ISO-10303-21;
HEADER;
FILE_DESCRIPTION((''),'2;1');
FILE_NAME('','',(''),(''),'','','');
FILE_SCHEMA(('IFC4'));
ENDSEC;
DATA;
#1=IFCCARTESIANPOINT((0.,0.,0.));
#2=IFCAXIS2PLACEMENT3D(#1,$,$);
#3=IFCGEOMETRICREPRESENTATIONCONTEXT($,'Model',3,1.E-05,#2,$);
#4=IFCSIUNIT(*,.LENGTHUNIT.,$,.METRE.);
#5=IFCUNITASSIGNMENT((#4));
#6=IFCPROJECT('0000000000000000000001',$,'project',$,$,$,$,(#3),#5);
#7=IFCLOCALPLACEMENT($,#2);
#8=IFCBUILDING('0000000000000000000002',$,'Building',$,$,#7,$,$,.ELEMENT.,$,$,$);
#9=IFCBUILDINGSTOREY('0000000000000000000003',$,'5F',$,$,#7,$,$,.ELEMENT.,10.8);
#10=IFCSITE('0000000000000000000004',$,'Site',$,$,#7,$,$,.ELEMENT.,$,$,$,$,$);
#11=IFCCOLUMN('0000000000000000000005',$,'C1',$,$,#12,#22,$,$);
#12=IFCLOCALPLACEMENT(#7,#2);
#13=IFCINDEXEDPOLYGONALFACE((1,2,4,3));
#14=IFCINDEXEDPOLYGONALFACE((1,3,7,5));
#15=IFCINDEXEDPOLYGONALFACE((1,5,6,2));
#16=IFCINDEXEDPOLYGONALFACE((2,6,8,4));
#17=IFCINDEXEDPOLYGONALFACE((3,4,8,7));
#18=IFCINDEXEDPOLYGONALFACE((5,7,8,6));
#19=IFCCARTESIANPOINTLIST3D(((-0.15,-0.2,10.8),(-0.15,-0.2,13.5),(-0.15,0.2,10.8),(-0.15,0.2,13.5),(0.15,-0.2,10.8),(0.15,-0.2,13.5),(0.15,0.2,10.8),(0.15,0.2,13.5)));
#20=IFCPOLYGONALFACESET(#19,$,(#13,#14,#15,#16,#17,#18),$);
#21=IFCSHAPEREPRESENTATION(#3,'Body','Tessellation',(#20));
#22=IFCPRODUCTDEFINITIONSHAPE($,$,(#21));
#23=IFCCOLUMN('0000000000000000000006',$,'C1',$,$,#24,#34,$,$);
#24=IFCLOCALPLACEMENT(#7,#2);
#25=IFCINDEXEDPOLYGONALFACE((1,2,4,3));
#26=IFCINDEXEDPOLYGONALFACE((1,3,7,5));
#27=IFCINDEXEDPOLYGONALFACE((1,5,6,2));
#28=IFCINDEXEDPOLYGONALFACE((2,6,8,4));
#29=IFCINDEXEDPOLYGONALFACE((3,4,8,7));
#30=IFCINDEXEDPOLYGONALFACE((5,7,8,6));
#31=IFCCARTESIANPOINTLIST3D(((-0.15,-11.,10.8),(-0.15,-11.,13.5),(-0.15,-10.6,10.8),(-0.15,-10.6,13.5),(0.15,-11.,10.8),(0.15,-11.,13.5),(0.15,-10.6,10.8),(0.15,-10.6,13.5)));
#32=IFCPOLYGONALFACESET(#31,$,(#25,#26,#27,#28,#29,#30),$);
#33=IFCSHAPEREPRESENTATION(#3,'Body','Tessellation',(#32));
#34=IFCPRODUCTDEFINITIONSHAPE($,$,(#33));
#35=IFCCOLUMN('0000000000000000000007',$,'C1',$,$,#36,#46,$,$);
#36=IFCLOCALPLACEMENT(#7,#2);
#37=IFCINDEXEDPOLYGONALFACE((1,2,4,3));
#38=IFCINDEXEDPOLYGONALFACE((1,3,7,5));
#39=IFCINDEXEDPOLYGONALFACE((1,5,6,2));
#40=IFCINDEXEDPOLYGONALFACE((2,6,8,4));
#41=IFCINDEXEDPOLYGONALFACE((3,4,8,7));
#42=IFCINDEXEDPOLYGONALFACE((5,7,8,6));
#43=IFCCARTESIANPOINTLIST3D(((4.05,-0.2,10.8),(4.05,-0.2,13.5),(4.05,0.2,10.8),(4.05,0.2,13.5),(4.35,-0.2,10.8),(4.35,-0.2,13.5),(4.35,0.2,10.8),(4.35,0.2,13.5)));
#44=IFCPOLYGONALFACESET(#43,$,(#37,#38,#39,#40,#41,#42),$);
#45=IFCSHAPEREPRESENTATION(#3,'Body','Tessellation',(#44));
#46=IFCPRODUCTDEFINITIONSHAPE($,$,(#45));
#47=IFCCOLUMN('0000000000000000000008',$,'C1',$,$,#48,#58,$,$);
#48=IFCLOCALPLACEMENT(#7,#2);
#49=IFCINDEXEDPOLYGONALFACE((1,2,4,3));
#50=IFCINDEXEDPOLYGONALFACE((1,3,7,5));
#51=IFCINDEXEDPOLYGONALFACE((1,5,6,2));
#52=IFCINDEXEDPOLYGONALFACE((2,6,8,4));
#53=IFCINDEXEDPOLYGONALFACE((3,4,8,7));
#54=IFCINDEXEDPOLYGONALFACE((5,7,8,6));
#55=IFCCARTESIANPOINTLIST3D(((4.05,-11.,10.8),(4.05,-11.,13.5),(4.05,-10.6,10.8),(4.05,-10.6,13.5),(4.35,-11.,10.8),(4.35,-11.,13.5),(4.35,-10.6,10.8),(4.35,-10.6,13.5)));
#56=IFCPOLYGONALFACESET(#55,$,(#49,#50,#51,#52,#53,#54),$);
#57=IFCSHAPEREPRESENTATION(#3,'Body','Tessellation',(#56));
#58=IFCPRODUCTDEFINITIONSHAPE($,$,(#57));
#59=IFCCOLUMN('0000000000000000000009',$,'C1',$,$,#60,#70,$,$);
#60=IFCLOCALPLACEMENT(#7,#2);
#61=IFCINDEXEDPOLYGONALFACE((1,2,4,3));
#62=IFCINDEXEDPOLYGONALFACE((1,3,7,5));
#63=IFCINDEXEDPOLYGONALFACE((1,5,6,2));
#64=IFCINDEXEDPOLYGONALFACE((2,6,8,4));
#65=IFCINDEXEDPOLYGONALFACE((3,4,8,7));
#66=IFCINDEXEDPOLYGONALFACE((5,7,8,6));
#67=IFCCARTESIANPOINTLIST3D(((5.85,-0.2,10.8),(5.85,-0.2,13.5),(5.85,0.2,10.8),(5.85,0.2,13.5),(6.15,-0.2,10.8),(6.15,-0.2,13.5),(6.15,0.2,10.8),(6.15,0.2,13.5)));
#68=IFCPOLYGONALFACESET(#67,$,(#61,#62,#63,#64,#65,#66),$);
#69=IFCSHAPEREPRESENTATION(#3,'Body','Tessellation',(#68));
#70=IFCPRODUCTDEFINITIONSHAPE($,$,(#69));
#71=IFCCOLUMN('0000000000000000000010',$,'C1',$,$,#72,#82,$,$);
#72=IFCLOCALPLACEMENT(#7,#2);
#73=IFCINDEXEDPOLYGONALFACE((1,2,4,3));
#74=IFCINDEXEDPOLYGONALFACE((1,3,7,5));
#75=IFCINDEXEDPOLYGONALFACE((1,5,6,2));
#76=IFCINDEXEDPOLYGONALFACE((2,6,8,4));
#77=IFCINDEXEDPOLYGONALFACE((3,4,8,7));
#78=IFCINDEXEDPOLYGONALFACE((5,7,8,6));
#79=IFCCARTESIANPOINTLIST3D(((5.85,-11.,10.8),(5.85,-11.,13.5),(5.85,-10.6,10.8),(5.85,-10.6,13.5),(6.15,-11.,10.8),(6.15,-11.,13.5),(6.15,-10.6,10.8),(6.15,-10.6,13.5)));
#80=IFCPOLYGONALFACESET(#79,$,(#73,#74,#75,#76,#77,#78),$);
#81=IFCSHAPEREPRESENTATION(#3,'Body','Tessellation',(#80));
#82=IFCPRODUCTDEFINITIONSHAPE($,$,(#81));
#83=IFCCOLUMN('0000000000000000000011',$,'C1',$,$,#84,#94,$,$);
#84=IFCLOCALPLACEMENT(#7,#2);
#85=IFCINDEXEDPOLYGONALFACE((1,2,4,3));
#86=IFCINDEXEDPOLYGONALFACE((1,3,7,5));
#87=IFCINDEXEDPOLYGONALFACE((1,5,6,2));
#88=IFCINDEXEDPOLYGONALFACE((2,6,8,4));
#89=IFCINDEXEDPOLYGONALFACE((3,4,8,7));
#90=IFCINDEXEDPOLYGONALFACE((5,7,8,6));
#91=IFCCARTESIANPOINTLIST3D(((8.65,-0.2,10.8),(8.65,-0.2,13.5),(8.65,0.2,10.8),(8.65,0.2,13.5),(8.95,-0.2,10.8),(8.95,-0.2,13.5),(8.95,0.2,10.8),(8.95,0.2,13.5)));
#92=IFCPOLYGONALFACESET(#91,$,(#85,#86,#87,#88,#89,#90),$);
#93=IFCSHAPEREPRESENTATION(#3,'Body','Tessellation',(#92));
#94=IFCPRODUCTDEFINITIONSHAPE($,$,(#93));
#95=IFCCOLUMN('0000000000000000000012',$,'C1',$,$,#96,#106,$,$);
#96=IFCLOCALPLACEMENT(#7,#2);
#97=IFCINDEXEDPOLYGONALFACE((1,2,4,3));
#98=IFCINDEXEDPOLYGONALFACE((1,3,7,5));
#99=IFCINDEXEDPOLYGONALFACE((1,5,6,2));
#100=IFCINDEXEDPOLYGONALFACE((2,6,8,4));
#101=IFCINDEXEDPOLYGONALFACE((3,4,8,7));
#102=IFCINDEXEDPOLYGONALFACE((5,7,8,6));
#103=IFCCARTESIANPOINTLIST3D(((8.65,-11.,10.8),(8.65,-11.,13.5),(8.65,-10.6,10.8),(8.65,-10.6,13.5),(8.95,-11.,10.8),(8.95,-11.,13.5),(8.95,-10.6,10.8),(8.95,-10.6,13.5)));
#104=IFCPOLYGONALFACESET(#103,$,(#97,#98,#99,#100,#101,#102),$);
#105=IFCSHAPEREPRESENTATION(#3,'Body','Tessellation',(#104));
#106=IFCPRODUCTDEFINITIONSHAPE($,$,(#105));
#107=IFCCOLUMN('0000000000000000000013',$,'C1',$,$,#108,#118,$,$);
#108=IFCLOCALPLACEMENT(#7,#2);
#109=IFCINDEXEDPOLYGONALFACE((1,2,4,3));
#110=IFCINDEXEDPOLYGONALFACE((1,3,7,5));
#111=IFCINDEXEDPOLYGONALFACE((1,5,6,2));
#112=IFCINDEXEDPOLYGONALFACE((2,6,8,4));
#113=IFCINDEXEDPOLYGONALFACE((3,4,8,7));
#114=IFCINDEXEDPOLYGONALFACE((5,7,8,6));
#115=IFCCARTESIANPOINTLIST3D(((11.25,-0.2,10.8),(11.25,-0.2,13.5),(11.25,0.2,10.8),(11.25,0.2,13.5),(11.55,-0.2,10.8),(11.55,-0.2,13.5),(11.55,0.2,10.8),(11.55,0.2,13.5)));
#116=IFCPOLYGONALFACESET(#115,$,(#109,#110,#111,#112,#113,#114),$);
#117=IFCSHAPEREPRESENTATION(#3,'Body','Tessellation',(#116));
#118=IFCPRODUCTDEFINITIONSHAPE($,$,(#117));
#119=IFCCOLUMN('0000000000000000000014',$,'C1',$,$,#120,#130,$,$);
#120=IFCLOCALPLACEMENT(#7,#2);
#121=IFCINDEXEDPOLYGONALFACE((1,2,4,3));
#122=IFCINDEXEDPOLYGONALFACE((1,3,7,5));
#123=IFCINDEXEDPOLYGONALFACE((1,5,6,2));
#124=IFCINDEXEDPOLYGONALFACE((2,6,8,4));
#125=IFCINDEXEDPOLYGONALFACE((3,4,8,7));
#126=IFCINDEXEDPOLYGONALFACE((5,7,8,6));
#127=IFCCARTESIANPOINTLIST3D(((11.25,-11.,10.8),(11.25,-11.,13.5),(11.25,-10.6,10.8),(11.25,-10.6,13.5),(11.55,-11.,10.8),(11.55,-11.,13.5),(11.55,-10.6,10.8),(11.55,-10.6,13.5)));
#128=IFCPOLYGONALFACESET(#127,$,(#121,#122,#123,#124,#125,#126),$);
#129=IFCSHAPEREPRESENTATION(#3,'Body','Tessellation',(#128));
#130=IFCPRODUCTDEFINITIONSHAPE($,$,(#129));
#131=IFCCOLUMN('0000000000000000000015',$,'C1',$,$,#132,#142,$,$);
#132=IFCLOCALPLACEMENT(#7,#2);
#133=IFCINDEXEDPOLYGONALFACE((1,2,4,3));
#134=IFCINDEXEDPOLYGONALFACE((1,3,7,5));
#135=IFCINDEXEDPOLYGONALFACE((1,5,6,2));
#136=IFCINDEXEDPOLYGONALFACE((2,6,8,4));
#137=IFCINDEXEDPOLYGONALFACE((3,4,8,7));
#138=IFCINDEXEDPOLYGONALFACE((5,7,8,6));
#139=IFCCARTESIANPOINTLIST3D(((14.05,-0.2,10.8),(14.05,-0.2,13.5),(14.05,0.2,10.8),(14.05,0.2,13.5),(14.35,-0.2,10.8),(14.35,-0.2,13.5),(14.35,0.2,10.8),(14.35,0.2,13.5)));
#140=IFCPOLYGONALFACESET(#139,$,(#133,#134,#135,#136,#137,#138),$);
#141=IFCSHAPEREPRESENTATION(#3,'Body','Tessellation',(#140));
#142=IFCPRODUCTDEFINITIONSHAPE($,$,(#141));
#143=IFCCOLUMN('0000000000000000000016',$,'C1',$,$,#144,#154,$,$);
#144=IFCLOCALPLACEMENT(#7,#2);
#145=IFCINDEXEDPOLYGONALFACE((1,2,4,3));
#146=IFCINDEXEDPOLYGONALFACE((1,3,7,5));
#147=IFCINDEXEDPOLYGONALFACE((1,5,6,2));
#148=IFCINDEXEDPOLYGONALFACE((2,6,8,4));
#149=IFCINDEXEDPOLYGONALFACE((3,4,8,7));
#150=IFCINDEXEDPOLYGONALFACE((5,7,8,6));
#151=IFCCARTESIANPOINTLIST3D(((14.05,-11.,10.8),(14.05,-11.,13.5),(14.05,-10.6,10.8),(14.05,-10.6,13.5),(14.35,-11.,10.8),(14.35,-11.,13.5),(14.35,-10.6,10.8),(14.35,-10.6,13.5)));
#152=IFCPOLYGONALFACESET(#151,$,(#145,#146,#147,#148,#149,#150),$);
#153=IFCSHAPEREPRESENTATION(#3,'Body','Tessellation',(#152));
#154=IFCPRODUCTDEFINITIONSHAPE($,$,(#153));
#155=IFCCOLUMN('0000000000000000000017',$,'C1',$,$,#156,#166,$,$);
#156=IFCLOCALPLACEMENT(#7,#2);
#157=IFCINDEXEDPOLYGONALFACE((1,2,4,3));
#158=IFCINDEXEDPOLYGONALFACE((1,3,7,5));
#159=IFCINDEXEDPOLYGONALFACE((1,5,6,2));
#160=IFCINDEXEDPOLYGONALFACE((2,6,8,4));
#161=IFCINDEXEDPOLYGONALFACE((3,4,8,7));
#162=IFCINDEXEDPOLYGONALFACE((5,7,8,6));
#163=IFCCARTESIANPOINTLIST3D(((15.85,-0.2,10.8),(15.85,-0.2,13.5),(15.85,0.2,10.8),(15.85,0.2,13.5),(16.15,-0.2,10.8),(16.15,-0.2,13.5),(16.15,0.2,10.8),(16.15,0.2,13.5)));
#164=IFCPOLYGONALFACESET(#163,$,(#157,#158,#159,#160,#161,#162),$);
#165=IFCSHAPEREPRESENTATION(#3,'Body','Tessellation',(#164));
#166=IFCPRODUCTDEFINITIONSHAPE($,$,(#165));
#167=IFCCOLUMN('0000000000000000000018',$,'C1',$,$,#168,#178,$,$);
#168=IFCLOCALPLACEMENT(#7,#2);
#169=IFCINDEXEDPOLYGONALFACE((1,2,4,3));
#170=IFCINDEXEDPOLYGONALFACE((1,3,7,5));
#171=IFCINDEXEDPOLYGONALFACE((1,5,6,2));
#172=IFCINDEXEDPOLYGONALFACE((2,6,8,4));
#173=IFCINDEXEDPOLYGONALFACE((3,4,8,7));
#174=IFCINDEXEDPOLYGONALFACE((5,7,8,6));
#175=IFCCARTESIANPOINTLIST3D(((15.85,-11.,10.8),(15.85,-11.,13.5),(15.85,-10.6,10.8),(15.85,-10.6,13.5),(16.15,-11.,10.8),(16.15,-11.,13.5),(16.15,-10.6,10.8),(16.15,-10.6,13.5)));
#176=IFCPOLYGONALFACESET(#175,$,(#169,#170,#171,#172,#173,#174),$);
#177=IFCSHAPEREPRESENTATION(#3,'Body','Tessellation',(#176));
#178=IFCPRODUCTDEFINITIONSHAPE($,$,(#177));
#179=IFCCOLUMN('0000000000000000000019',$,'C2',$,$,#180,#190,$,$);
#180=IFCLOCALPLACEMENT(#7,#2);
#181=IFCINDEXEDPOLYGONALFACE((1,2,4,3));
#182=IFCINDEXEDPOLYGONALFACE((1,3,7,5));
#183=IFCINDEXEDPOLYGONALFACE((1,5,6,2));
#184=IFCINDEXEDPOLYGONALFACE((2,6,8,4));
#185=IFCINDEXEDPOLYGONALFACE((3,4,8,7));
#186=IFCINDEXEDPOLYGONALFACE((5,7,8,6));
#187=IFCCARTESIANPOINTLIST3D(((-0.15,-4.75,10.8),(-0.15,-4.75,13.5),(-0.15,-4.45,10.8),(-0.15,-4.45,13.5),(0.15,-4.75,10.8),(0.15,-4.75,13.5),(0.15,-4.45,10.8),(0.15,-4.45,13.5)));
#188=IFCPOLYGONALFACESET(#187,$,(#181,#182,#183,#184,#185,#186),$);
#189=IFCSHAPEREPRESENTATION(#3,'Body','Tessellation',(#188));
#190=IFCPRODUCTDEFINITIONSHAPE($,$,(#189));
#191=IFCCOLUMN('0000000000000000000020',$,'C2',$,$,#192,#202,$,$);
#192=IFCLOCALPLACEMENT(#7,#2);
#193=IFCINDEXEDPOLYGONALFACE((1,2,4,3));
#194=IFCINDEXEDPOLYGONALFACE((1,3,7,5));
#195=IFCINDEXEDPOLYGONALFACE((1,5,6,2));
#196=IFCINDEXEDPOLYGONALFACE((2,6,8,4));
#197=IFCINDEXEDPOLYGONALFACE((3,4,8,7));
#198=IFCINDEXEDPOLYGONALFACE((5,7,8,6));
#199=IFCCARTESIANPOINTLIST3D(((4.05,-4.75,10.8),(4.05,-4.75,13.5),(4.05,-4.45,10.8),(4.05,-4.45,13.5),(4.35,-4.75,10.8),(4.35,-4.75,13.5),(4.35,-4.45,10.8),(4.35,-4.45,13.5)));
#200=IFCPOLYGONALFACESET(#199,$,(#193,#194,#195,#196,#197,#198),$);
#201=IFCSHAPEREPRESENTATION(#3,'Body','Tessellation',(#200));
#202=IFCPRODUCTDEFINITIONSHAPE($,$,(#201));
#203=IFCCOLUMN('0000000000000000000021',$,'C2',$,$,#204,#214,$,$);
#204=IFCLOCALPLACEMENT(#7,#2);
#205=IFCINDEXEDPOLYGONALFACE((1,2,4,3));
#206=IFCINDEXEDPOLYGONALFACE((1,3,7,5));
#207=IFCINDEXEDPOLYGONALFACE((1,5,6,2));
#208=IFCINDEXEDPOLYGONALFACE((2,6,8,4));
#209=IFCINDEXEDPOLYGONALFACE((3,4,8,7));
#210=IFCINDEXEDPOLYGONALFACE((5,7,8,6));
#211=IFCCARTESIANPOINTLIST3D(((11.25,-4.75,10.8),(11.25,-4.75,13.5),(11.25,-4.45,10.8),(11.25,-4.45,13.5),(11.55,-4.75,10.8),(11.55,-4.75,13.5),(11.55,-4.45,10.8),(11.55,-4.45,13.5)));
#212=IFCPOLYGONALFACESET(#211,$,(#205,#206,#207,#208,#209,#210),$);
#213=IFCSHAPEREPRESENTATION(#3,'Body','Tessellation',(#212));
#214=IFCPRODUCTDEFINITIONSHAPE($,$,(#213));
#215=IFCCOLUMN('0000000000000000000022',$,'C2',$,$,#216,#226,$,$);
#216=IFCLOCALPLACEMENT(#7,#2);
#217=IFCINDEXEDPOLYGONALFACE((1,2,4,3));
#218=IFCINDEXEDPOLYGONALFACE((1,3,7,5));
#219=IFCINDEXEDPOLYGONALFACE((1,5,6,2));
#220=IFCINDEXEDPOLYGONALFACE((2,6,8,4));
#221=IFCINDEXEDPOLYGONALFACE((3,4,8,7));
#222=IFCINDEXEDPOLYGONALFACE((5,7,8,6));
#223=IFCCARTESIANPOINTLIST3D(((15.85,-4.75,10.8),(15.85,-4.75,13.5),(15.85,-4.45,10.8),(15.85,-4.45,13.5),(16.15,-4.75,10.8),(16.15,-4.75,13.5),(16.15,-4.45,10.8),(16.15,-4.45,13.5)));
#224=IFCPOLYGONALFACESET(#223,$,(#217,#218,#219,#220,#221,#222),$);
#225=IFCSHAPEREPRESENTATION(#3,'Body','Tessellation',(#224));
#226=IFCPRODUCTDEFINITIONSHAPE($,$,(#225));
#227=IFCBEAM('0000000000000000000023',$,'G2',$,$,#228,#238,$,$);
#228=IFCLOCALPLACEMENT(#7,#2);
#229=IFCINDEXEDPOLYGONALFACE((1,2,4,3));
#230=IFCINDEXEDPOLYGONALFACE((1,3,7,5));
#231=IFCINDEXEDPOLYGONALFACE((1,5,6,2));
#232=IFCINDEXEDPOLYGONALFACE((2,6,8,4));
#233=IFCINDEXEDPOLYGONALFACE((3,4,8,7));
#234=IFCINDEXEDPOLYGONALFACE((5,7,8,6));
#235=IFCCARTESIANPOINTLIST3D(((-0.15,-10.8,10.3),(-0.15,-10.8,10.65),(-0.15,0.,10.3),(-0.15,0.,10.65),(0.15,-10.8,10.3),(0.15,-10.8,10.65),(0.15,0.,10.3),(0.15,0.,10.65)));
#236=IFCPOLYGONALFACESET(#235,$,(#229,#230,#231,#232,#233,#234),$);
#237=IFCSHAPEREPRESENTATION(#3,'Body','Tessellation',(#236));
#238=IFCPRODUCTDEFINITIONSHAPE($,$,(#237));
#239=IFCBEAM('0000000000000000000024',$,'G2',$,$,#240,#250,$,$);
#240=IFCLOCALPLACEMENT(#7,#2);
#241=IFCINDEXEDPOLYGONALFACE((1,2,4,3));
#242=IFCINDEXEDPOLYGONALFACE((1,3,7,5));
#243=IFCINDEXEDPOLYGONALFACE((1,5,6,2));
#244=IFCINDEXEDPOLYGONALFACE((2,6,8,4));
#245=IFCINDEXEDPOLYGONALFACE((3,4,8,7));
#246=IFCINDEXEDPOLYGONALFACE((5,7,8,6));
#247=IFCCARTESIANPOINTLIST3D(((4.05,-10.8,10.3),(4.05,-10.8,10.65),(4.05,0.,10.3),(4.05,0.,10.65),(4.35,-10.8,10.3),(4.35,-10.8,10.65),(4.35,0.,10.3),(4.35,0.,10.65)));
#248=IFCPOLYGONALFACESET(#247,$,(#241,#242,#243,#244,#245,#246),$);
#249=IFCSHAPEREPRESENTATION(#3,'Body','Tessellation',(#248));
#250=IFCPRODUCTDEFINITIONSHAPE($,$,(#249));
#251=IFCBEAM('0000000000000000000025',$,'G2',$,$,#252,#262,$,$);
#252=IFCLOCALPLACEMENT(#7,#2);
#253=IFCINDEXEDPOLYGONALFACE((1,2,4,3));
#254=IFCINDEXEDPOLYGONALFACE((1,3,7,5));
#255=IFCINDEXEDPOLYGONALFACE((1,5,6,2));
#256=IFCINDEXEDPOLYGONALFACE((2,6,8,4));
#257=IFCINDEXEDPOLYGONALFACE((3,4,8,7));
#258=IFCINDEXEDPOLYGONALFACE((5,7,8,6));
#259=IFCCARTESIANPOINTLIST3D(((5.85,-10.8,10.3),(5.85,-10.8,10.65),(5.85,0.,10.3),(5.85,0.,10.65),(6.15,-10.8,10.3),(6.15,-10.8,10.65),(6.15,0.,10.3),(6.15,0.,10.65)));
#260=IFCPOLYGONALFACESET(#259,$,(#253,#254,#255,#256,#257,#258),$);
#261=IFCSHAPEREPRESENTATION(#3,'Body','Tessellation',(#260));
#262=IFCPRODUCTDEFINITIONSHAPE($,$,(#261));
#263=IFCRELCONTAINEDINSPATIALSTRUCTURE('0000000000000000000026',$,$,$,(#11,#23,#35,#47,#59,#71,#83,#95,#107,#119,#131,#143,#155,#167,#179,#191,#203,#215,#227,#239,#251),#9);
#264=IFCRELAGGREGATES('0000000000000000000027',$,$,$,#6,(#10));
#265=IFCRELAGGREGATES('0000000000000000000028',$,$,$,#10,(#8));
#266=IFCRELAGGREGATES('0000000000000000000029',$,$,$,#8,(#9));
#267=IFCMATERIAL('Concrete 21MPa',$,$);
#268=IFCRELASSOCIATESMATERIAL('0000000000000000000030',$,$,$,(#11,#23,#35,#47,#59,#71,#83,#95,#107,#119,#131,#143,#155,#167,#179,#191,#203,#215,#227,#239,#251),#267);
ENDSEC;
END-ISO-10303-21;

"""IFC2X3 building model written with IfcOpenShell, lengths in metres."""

from ifc_helpers import new_model, si_unit, frame, origin, origin_2d, place, context, project, spatial, rectangle, extrude, material, element, save


model = new_model("IFC2X3")

# Units and contexts
model_context = context("Model", 3, precision=1e-05, world=origin())
ifc_project = project(units=[si_unit("LENGTHUNIT", "METRE")], contexts=[model_context])

# Site, building, storey
placement = place(None, origin())
site = spatial("IfcSite", under=ifc_project, at=placement, Name="Site", CompositionType="ELEMENT")
building = spatial("IfcBuilding", under=site, at=placement, Name="Building", CompositionType="ELEMENT")
storey = spatial("IfcBuildingStorey", under=building, at=placement, Name="5F", CompositionType="ELEMENT", Elevation=10.8)

# Columns
ifc_material = material(Name="Concrete 21MPa")
for number, where, name in (
    (1, (0.0, 0.0, 10.8), "C1"),
    (2, (0.0, -10.8, 10.8), "C1"),
    (3, (4.2, 0.0, 10.8), "C1"),
    (4, (4.2, -10.8, 10.8), "C1"),
    (5, (6.0, 0.0, 10.8), "C1"),
    (6, (6.0, -10.8, 10.8), "C1"),
    (7, (8.8, 0.0, 10.8), "C1"),
    (8, (8.8, -10.8, 10.8), "C1"),
    (9, (11.4, 0.0, 10.8), "C1"),
    (10, (11.4, -10.8, 10.8), "C1"),
    (11, (14.2, 0.0, 10.8), "C1"),
    (12, (14.2, -10.8, 10.8), "C1"),
    (13, (16.0, 0.0, 10.8), "C1"),
    (14, (16.0, -10.8, 10.8), "C1"),
):
    element("IfcColumn", number, at=place(None, frame(where)), inside=storey, material=ifc_material, Name=name, context=model_context, shape_type="SweptSolid", body=[
        extrude(rectangle(XDim=0.3, YDim=0.4, at=origin_2d()), origin(), (0.0, 0.0, 1.0), 2.7),
    ])
for number, where, name in (
    (15, (0.0, -4.6, 10.8), "C2"),
    (16, (4.2, -4.6, 10.8), "C2"),
    (17, (11.4, -4.6, 10.8), "C2"),
    (18, (16.0, -4.6, 10.8), "C2"),
):
    element("IfcColumn", number, at=place(None, frame(where)), inside=storey, material=ifc_material, Name=name, context=model_context, shape_type="SweptSolid", body=[
        extrude(rectangle(XDim=0.3, YDim=0.3, at=origin_2d()), origin(), (0.0, 0.0, 1.0), 2.7),
    ])

# Beams
for number, where, name in (
    (19, (0.0, -5.4, 10.3), "G2"),
    (20, (4.2, -5.4, 10.3), "G2"),
    (21, (6.0, -5.4, 10.3), "G2"),
):
    element("IfcBeam", number, at=place(None, frame(where)), inside=storey, material=ifc_material, Name=name, context=model_context, shape_type="SweptSolid", body=[
        extrude(rectangle(XDim=0.3, YDim=10.8, at=origin_2d()), origin(), (0.0, 0.0, 1.0), 0.35),
    ])

save(model, "model.ifc")
